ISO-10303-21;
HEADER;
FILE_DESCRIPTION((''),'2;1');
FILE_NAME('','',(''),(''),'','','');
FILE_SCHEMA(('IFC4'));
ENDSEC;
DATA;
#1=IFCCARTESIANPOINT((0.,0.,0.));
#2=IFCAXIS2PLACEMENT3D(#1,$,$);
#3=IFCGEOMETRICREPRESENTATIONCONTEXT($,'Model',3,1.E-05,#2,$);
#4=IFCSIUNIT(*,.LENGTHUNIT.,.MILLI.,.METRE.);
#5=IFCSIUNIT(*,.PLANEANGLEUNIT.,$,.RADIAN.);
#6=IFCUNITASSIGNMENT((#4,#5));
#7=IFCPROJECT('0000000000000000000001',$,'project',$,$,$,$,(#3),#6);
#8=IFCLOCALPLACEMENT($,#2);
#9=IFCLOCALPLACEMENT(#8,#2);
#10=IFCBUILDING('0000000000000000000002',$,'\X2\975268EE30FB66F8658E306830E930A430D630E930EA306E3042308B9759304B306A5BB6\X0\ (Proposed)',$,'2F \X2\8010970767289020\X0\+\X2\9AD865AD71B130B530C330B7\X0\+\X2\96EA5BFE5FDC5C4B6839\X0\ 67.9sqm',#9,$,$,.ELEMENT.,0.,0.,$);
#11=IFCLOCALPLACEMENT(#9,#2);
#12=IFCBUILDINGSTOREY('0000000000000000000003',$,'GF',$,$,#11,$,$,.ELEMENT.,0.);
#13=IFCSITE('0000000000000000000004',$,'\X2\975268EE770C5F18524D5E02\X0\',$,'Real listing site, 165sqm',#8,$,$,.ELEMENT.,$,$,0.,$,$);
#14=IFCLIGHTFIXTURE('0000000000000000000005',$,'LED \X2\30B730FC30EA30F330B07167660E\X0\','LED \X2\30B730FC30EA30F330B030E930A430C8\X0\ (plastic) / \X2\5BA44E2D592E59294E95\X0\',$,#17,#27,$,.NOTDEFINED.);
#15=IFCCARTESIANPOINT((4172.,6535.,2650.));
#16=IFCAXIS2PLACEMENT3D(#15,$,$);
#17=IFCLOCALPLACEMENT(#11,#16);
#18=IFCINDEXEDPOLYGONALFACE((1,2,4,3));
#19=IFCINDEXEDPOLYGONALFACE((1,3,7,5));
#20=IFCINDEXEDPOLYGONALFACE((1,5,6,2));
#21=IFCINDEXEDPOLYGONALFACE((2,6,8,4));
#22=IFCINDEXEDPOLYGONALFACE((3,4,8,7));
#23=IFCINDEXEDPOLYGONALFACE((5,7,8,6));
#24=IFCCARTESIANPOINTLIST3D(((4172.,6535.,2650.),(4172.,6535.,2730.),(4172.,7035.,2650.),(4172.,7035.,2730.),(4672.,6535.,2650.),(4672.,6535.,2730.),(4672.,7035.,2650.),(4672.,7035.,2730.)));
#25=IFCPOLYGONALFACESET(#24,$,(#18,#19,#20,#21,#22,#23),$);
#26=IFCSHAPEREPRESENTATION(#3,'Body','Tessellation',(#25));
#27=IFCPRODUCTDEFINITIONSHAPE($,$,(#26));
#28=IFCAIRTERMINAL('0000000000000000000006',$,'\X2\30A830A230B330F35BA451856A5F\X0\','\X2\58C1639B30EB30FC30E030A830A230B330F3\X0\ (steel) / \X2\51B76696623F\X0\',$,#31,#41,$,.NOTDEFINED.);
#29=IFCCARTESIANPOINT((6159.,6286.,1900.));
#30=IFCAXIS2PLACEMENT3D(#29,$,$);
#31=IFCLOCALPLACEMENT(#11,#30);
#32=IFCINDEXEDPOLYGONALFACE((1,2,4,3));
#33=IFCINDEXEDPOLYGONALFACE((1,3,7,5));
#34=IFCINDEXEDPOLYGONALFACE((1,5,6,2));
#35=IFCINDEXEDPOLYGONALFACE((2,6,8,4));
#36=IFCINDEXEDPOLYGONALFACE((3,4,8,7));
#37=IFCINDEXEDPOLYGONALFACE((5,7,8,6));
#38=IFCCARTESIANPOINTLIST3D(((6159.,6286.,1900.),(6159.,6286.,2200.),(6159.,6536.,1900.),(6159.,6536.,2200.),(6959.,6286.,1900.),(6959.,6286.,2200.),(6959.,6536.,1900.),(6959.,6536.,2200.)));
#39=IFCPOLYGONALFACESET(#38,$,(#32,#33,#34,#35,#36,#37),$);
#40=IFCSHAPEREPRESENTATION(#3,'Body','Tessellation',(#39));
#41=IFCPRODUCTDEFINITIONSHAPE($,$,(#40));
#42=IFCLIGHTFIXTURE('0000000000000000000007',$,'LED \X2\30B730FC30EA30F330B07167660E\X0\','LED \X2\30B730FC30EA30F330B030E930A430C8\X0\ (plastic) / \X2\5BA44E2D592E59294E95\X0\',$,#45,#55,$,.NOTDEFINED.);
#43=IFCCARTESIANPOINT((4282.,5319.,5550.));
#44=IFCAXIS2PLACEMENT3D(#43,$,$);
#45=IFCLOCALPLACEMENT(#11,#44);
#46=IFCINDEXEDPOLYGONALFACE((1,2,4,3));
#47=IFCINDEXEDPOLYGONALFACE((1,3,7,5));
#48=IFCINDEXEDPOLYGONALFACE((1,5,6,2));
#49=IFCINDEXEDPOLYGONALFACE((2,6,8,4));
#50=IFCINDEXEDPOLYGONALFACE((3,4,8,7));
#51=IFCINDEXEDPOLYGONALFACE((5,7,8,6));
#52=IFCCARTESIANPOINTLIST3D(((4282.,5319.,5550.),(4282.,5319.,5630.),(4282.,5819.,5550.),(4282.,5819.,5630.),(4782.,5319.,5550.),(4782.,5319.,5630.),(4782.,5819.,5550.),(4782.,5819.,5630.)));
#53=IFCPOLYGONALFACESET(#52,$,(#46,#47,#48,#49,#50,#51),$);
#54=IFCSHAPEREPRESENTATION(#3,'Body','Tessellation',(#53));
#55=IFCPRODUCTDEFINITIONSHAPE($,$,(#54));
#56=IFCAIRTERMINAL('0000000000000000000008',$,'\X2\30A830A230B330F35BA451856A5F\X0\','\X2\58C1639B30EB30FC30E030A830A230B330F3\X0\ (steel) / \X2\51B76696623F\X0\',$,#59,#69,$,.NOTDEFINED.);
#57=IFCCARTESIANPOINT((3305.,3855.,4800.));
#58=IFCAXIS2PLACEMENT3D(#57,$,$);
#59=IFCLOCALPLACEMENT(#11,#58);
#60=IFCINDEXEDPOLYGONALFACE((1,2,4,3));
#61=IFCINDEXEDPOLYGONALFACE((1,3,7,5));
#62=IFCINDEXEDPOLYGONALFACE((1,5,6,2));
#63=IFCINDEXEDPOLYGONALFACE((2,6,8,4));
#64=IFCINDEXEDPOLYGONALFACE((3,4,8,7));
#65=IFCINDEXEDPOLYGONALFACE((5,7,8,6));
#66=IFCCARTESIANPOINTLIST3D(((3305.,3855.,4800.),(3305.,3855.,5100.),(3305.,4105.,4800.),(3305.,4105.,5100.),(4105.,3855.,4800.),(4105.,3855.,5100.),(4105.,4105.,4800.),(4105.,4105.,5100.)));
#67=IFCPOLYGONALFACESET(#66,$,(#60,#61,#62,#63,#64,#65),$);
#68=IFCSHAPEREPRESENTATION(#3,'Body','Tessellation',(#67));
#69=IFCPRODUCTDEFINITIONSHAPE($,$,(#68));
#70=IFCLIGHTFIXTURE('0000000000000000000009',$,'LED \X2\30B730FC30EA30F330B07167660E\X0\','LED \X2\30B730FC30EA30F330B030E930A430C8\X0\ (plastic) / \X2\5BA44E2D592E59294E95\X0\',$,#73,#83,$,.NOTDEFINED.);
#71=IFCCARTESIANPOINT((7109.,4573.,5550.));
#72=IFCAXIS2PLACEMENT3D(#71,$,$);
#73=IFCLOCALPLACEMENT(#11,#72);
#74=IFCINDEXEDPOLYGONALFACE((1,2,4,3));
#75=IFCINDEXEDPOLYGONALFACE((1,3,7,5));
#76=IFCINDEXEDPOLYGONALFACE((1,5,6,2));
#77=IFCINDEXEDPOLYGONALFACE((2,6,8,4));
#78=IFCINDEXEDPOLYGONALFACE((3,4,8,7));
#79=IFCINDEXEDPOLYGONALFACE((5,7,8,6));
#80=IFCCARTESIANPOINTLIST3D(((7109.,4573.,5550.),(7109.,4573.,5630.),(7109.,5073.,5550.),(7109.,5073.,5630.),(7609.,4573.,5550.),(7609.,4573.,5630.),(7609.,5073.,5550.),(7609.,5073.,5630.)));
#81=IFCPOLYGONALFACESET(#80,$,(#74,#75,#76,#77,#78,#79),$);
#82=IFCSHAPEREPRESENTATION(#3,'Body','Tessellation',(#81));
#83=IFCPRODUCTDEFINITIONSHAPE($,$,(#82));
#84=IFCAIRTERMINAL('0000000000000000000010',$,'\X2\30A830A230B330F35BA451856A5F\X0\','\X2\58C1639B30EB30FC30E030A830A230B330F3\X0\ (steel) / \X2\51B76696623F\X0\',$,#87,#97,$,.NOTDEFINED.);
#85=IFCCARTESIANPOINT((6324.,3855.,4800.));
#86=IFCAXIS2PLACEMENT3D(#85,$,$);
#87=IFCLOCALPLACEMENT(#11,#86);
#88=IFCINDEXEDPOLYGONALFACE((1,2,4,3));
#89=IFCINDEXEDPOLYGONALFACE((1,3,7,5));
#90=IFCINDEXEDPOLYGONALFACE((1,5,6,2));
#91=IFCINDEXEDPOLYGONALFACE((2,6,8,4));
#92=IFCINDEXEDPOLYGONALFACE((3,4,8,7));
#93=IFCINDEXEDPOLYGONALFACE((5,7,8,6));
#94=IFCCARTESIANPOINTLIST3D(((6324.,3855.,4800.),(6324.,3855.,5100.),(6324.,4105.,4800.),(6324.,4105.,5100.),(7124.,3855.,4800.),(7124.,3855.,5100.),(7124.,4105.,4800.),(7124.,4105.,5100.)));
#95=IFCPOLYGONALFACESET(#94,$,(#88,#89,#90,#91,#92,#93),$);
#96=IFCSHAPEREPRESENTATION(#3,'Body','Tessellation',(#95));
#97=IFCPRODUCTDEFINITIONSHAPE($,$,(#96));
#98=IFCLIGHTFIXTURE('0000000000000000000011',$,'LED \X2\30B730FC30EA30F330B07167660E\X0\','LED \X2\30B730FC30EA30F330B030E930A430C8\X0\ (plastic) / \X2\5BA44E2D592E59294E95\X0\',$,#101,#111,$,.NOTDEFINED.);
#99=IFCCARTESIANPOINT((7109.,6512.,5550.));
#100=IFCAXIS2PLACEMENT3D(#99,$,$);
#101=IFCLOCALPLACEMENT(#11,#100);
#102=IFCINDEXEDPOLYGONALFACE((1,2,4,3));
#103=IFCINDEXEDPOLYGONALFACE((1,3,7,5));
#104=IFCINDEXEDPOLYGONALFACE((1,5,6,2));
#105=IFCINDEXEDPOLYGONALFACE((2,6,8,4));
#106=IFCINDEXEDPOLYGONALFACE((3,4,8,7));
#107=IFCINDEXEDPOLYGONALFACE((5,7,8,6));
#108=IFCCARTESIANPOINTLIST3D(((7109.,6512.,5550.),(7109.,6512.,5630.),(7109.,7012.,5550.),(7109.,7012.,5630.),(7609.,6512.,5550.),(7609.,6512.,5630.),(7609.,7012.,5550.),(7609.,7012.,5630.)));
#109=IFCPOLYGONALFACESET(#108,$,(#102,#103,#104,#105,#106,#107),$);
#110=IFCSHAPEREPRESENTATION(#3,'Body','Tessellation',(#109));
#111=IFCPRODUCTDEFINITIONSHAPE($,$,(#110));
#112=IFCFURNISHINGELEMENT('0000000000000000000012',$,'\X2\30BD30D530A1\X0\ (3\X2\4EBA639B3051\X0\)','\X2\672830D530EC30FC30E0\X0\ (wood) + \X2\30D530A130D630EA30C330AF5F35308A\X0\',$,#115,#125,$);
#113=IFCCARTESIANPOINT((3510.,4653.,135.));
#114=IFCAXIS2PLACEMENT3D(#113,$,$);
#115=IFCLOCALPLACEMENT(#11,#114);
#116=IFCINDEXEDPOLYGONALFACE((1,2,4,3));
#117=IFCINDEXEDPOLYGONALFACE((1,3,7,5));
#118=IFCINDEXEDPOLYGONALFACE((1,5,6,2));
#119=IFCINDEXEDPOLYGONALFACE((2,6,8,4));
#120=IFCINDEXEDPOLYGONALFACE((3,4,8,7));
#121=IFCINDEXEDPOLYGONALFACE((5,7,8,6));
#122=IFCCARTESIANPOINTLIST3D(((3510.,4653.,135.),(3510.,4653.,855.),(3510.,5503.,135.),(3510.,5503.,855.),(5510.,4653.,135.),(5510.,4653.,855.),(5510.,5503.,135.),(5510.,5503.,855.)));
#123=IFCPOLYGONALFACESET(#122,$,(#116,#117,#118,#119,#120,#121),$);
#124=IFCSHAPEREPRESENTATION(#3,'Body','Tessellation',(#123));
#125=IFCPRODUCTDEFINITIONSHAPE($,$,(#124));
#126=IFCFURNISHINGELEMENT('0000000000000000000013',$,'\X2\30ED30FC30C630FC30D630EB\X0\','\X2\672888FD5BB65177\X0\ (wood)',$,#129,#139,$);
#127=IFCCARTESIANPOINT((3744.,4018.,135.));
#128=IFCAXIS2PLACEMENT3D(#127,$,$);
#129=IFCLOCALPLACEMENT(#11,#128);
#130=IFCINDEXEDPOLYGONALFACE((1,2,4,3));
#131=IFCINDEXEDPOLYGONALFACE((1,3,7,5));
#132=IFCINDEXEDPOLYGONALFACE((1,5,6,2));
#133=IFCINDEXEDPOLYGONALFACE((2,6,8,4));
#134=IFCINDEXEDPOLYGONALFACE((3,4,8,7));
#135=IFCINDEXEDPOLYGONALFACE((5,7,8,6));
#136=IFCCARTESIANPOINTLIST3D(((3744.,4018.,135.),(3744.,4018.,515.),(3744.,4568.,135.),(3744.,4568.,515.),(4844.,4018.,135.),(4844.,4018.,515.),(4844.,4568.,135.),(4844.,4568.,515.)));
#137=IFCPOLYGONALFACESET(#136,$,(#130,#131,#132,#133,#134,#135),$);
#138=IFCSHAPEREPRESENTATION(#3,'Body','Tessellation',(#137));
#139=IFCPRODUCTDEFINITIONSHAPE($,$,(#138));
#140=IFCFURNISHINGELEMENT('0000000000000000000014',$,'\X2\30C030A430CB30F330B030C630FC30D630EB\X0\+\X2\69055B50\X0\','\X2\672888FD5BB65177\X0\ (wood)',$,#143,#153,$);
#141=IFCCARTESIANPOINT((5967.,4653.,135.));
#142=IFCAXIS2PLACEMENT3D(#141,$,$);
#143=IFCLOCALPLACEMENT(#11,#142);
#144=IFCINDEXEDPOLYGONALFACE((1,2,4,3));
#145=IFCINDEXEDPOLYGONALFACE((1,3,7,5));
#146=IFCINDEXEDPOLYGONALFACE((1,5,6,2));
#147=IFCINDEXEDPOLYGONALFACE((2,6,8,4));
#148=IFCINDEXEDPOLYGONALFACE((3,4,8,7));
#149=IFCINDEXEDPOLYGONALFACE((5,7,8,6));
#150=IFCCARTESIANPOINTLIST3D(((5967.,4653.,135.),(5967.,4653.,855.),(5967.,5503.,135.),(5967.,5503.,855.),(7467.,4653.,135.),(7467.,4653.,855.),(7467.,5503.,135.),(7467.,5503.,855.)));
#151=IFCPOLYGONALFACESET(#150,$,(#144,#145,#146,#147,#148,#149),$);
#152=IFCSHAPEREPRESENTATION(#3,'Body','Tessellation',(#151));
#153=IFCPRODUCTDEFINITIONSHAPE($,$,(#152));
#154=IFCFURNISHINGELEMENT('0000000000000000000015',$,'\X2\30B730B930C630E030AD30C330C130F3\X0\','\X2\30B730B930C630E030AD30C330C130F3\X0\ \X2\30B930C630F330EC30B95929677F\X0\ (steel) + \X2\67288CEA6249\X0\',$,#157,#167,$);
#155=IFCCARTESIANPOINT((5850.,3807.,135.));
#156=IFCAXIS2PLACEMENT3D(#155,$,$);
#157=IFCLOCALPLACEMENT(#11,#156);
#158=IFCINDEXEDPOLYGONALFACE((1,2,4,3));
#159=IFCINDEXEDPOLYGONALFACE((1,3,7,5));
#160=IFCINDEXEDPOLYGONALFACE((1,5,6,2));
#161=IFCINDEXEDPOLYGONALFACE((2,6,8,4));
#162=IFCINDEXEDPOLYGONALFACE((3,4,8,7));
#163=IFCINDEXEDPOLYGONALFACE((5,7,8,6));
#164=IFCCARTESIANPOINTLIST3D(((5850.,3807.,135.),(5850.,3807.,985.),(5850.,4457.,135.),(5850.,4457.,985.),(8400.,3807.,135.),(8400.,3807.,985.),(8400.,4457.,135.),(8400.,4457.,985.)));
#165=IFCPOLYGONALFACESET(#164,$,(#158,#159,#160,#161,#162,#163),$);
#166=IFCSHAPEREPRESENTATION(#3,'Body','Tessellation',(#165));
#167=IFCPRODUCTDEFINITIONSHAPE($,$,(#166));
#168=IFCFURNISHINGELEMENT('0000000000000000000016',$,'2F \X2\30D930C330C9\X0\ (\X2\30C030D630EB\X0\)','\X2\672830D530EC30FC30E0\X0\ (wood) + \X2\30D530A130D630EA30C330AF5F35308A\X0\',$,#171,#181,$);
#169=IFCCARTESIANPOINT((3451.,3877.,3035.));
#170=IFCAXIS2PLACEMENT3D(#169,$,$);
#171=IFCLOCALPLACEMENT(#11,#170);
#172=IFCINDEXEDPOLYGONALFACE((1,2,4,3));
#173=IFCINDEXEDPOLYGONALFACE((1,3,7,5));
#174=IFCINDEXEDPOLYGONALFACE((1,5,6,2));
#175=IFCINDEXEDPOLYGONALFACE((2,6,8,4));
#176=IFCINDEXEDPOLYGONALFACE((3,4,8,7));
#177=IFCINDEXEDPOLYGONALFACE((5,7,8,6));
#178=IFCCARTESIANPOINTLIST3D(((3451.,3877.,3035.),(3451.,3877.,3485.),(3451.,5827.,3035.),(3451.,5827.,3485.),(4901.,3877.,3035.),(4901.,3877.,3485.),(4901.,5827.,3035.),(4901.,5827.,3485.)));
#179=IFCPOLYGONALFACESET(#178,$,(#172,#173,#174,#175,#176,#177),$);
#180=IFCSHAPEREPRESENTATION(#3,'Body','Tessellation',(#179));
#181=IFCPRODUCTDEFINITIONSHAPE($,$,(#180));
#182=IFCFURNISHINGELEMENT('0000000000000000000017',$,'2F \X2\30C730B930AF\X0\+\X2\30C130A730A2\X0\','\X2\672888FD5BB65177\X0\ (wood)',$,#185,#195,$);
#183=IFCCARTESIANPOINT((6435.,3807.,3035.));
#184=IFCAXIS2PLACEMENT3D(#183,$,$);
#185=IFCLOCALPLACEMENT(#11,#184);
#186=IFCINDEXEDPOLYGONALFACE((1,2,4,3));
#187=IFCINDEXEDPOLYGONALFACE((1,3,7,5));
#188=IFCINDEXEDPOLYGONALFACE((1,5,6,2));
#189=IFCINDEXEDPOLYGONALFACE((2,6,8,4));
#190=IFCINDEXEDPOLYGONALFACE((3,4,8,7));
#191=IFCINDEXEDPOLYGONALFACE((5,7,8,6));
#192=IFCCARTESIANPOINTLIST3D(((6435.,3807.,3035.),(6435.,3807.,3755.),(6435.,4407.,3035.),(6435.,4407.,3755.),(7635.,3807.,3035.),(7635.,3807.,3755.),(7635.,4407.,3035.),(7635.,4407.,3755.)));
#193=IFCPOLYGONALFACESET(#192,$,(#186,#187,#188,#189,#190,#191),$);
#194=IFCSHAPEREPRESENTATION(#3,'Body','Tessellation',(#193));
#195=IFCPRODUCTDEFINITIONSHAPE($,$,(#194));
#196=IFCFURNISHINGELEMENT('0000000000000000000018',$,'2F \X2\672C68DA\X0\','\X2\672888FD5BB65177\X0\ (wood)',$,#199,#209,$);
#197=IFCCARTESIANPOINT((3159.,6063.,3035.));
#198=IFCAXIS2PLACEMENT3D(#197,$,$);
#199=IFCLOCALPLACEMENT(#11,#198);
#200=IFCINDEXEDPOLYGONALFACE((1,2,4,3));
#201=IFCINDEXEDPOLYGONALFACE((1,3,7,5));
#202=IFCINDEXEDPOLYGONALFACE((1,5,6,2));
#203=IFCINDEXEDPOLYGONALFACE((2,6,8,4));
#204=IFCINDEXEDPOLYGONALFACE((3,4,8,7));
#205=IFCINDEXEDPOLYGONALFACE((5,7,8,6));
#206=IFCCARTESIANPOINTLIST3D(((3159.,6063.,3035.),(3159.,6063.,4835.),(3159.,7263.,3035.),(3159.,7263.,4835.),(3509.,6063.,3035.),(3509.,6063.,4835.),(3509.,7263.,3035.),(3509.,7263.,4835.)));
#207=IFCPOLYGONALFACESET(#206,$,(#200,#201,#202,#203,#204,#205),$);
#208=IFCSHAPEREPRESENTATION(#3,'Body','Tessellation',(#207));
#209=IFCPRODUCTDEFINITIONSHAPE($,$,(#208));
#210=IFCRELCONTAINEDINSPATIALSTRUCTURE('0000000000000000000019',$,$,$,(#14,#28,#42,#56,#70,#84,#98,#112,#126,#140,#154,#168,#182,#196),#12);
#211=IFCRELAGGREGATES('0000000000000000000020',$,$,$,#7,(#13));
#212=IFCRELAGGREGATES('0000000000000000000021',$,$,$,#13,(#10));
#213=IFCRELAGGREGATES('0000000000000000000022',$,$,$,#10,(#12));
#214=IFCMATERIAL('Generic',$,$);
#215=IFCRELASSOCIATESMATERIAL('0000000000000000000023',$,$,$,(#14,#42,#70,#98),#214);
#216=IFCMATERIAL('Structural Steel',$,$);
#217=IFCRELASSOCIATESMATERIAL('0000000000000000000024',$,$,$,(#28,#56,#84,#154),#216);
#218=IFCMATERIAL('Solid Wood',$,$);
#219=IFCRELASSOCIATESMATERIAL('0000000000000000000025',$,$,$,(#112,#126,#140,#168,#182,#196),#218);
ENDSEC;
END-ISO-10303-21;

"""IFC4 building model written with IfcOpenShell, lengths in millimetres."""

from ifc_helpers import new_model, si_unit, frame, frame_2d, origin, place, context, project, spatial, rectangle, extrude, material, element, save


model = new_model("IFC4")

# Units and contexts
model_context = context("Model", 3, precision=1e-05, world=origin())
ifc_project = project(units=[si_unit("LENGTHUNIT", "METRE", prefix="MILLI"), si_unit("PLANEANGLEUNIT", "RADIAN")], contexts=[model_context])

# Site, building, storey
site_placement = place(None, origin())
site = spatial("IfcSite", under=ifc_project, at=site_placement, Name="青森県弘前市", ObjectType="Real listing site, 165sqm", CompositionType="ELEMENT", RefElevation=0.0)
building_placement = place(site_placement, origin())
building = spatial("IfcBuilding", under=site, at=building_placement, Name="青森・書斎とライブラリのある静かな家 (Proposed)", ObjectType="2F 耐震木造+高断熱サッシ+雪対応屋根 67.9sqm", CompositionType="ELEMENT", ElevationOfRefHeight=0.0, ElevationOfTerrain=0.0)
storey_placement = place(building_placement, origin())
storey = spatial("IfcBuildingStorey", under=building, at=storey_placement, Name="GF", CompositionType="ELEMENT", Elevation=0.0)

# Shared definitions
ifc_material_1 = material(Name="Solid Wood")

# Shared definitions
ifc_material_2 = material(Name="Structural Steel")

# Shared definitions
ifc_material_3 = material(Name="Generic")

# Light fixture
light_fixture_1_placement = place(storey_placement, frame((4172.0, 6535.0, 2650.0)))
element("IfcLightFixture", 1, at=light_fixture_1_placement, inside=storey, material=ifc_material_3, Name="LED シーリング照明", Description="LED シーリングライト (plastic) / 室中央天井", PredefinedType="NOTDEFINED", context=model_context, shape_type="SweptSolid", body=[
    extrude(rectangle(XDim=500.0, YDim=500.0, at=frame_2d((250.0, 250.0))), frame((4172.0, 6535.0, 2650.0)), (0.0, 0.0, 1.0), 80.0),
])

# Air terminal
air_terminal_1_placement = place(storey_placement, frame((6159.0, 6286.0, 1900.0)))
element("IfcAirTerminal", 2, at=air_terminal_1_placement, inside=storey, material=ifc_material_2, Name="エアコン室内機", Description="壁掛ルームエアコン (steel) / 冷暖房", PredefinedType="NOTDEFINED", context=model_context, shape_type="SweptSolid", body=[
    extrude(rectangle(XDim=800.0, YDim=250.0, at=frame_2d((400.0, 125.0))), frame((6159.0, 6286.0, 1900.0)), (0.0, 0.0, 1.0), 300.0),
])

# Light fixture
light_fixture_2_placement = place(storey_placement, frame((4282.0, 5319.0, 5550.0)))
element("IfcLightFixture", 3, at=light_fixture_2_placement, inside=storey, material=ifc_material_3, Name="LED シーリング照明", Description="LED シーリングライト (plastic) / 室中央天井", PredefinedType="NOTDEFINED", context=model_context, shape_type="SweptSolid", body=[
    extrude(rectangle(XDim=500.0, YDim=500.0, at=frame_2d((250.0, 250.0))), frame((4282.0, 5319.0, 5550.0)), (0.0, 0.0, 1.0), 80.0),
])

# Air terminal
air_terminal_2_placement = place(storey_placement, frame((3305.0, 3855.0, 4800.0)))
element("IfcAirTerminal", 4, at=air_terminal_2_placement, inside=storey, material=ifc_material_2, Name="エアコン室内機", Description="壁掛ルームエアコン (steel) / 冷暖房", PredefinedType="NOTDEFINED", context=model_context, shape_type="SweptSolid", body=[
    extrude(rectangle(XDim=800.0, YDim=250.0, at=frame_2d((400.0, 125.0))), frame((3305.0, 3855.0, 4800.0)), (0.0, 0.0, 1.0), 300.0),
])

# Light fixture
light_fixture_3_placement = place(storey_placement, frame((7109.0, 4573.0, 5550.0)))
element("IfcLightFixture", 5, at=light_fixture_3_placement, inside=storey, material=ifc_material_3, Name="LED シーリング照明", Description="LED シーリングライト (plastic) / 室中央天井", PredefinedType="NOTDEFINED", context=model_context, shape_type="SweptSolid", body=[
    extrude(rectangle(XDim=500.0, YDim=500.0, at=frame_2d((250.0, 250.0))), frame((7109.0, 4573.0, 5550.0)), (0.0, 0.0, 1.0), 80.0),
])

# Air terminal
air_terminal_3_placement = place(storey_placement, frame((6324.0, 3855.0, 4800.0)))
element("IfcAirTerminal", 6, at=air_terminal_3_placement, inside=storey, material=ifc_material_2, Name="エアコン室内機", Description="壁掛ルームエアコン (steel) / 冷暖房", PredefinedType="NOTDEFINED", context=model_context, shape_type="SweptSolid", body=[
    extrude(rectangle(XDim=800.0, YDim=250.0, at=frame_2d((400.0, 125.0))), frame((6324.0, 3855.0, 4800.0)), (0.0, 0.0, 1.0), 300.0),
])

# Light fixture
light_fixture_4_placement = place(storey_placement, frame((7109.0, 6512.0, 5550.0)))
element("IfcLightFixture", 7, at=light_fixture_4_placement, inside=storey, material=ifc_material_3, Name="LED シーリング照明", Description="LED シーリングライト (plastic) / 室中央天井", PredefinedType="NOTDEFINED", context=model_context, shape_type="SweptSolid", body=[
    extrude(rectangle(XDim=500.0, YDim=500.0, at=frame_2d((250.0, 250.0))), frame((7109.0, 6512.0, 5550.0)), (0.0, 0.0, 1.0), 80.0),
])

# Furnishing elements
furnishing_1_placement = place(storey_placement, frame((3510.0, 4653.0, 135.0)))
element("IfcFurnishingElement", 8, at=furnishing_1_placement, inside=storey, material=ifc_material_1, Name="ソファ (3人掛け)", Description="木フレーム (wood) + ファブリック張り", context=model_context, shape_type="SweptSolid", body=[
    extrude(rectangle(XDim=2000.0, YDim=850.0, at=frame_2d((1000.0, 425.0))), frame((3510.0, 4653.0, 135.0)), (0.0, 0.0, 1.0), 720.0),
])
furnishing_2_placement = place(storey_placement, frame((3744.0, 4018.0, 135.0)))
element("IfcFurnishingElement", 9, at=furnishing_2_placement, inside=storey, material=ifc_material_1, Name="ローテーブル", Description="木製家具 (wood)", context=model_context, shape_type="SweptSolid", body=[
    extrude(rectangle(XDim=1100.0, YDim=550.0, at=frame_2d((550.0, 275.0))), frame((3744.0, 4018.0, 135.0)), (0.0, 0.0, 1.0), 380.0),
])
furnishing_3_placement = place(storey_placement, frame((5967.0, 4653.0, 135.0)))
element("IfcFurnishingElement", 10, at=furnishing_3_placement, inside=storey, material=ifc_material_1, Name="ダイニングテーブル+椅子", Description="木製家具 (wood)", context=model_context, shape_type="SweptSolid", body=[
    extrude(rectangle(XDim=1500.0, YDim=850.0, at=frame_2d((750.0, 425.0))), frame((5967.0, 4653.0, 135.0)), (0.0, 0.0, 1.0), 720.0),
])
furnishing_4_placement = place(storey_placement, frame((5850.0, 3807.0, 135.0)))
element("IfcFurnishingElement", 11, at=furnishing_4_placement, inside=storey, material=ifc_material_2, Name="システムキッチン", Description="システムキッチン ステンレス天板 (steel) + 木質扉", context=model_context, shape_type="SweptSolid", body=[
    extrude(rectangle(XDim=2550.0, YDim=650.0, at=frame_2d((1275.0, 325.0))), frame((5850.0, 3807.0, 135.0)), (0.0, 0.0, 1.0), 850.0),
])
furnishing_5_placement = place(storey_placement, frame((3451.0, 3877.0, 3035.0)))
element("IfcFurnishingElement", 12, at=furnishing_5_placement, inside=storey, material=ifc_material_1, Name="2F ベッド (ダブル)", Description="木フレーム (wood) + ファブリック張り", context=model_context, shape_type="SweptSolid", body=[
    extrude(rectangle(XDim=1450.0, YDim=1950.0, at=frame_2d((725.0, 975.0))), frame((3451.0, 3877.0, 3035.0)), (0.0, 0.0, 1.0), 450.0),
])
furnishing_6_placement = place(storey_placement, frame((6435.0, 3807.0, 3035.0)))
element("IfcFurnishingElement", 13, at=furnishing_6_placement, inside=storey, material=ifc_material_1, Name="2F デスク+チェア", Description="木製家具 (wood)", context=model_context, shape_type="SweptSolid", body=[
    extrude(rectangle(XDim=1200.0, YDim=600.0, at=frame_2d((600.0, 300.0))), frame((6435.0, 3807.0, 3035.0)), (0.0, 0.0, 1.0), 720.0),
])
furnishing_7_placement = place(storey_placement, frame((3159.0, 6063.0, 3035.0)))
element("IfcFurnishingElement", 14, at=furnishing_7_placement, inside=storey, material=ifc_material_1, Name="2F 本棚", Description="木製家具 (wood)", context=model_context, shape_type="SweptSolid", body=[
    extrude(rectangle(XDim=350.0, YDim=1200.0, at=frame_2d((175.0, 600.0))), frame((3159.0, 6063.0, 3035.0)), (0.0, 0.0, 1.0), 1800.0),
])

save(model, "model.ifc")
